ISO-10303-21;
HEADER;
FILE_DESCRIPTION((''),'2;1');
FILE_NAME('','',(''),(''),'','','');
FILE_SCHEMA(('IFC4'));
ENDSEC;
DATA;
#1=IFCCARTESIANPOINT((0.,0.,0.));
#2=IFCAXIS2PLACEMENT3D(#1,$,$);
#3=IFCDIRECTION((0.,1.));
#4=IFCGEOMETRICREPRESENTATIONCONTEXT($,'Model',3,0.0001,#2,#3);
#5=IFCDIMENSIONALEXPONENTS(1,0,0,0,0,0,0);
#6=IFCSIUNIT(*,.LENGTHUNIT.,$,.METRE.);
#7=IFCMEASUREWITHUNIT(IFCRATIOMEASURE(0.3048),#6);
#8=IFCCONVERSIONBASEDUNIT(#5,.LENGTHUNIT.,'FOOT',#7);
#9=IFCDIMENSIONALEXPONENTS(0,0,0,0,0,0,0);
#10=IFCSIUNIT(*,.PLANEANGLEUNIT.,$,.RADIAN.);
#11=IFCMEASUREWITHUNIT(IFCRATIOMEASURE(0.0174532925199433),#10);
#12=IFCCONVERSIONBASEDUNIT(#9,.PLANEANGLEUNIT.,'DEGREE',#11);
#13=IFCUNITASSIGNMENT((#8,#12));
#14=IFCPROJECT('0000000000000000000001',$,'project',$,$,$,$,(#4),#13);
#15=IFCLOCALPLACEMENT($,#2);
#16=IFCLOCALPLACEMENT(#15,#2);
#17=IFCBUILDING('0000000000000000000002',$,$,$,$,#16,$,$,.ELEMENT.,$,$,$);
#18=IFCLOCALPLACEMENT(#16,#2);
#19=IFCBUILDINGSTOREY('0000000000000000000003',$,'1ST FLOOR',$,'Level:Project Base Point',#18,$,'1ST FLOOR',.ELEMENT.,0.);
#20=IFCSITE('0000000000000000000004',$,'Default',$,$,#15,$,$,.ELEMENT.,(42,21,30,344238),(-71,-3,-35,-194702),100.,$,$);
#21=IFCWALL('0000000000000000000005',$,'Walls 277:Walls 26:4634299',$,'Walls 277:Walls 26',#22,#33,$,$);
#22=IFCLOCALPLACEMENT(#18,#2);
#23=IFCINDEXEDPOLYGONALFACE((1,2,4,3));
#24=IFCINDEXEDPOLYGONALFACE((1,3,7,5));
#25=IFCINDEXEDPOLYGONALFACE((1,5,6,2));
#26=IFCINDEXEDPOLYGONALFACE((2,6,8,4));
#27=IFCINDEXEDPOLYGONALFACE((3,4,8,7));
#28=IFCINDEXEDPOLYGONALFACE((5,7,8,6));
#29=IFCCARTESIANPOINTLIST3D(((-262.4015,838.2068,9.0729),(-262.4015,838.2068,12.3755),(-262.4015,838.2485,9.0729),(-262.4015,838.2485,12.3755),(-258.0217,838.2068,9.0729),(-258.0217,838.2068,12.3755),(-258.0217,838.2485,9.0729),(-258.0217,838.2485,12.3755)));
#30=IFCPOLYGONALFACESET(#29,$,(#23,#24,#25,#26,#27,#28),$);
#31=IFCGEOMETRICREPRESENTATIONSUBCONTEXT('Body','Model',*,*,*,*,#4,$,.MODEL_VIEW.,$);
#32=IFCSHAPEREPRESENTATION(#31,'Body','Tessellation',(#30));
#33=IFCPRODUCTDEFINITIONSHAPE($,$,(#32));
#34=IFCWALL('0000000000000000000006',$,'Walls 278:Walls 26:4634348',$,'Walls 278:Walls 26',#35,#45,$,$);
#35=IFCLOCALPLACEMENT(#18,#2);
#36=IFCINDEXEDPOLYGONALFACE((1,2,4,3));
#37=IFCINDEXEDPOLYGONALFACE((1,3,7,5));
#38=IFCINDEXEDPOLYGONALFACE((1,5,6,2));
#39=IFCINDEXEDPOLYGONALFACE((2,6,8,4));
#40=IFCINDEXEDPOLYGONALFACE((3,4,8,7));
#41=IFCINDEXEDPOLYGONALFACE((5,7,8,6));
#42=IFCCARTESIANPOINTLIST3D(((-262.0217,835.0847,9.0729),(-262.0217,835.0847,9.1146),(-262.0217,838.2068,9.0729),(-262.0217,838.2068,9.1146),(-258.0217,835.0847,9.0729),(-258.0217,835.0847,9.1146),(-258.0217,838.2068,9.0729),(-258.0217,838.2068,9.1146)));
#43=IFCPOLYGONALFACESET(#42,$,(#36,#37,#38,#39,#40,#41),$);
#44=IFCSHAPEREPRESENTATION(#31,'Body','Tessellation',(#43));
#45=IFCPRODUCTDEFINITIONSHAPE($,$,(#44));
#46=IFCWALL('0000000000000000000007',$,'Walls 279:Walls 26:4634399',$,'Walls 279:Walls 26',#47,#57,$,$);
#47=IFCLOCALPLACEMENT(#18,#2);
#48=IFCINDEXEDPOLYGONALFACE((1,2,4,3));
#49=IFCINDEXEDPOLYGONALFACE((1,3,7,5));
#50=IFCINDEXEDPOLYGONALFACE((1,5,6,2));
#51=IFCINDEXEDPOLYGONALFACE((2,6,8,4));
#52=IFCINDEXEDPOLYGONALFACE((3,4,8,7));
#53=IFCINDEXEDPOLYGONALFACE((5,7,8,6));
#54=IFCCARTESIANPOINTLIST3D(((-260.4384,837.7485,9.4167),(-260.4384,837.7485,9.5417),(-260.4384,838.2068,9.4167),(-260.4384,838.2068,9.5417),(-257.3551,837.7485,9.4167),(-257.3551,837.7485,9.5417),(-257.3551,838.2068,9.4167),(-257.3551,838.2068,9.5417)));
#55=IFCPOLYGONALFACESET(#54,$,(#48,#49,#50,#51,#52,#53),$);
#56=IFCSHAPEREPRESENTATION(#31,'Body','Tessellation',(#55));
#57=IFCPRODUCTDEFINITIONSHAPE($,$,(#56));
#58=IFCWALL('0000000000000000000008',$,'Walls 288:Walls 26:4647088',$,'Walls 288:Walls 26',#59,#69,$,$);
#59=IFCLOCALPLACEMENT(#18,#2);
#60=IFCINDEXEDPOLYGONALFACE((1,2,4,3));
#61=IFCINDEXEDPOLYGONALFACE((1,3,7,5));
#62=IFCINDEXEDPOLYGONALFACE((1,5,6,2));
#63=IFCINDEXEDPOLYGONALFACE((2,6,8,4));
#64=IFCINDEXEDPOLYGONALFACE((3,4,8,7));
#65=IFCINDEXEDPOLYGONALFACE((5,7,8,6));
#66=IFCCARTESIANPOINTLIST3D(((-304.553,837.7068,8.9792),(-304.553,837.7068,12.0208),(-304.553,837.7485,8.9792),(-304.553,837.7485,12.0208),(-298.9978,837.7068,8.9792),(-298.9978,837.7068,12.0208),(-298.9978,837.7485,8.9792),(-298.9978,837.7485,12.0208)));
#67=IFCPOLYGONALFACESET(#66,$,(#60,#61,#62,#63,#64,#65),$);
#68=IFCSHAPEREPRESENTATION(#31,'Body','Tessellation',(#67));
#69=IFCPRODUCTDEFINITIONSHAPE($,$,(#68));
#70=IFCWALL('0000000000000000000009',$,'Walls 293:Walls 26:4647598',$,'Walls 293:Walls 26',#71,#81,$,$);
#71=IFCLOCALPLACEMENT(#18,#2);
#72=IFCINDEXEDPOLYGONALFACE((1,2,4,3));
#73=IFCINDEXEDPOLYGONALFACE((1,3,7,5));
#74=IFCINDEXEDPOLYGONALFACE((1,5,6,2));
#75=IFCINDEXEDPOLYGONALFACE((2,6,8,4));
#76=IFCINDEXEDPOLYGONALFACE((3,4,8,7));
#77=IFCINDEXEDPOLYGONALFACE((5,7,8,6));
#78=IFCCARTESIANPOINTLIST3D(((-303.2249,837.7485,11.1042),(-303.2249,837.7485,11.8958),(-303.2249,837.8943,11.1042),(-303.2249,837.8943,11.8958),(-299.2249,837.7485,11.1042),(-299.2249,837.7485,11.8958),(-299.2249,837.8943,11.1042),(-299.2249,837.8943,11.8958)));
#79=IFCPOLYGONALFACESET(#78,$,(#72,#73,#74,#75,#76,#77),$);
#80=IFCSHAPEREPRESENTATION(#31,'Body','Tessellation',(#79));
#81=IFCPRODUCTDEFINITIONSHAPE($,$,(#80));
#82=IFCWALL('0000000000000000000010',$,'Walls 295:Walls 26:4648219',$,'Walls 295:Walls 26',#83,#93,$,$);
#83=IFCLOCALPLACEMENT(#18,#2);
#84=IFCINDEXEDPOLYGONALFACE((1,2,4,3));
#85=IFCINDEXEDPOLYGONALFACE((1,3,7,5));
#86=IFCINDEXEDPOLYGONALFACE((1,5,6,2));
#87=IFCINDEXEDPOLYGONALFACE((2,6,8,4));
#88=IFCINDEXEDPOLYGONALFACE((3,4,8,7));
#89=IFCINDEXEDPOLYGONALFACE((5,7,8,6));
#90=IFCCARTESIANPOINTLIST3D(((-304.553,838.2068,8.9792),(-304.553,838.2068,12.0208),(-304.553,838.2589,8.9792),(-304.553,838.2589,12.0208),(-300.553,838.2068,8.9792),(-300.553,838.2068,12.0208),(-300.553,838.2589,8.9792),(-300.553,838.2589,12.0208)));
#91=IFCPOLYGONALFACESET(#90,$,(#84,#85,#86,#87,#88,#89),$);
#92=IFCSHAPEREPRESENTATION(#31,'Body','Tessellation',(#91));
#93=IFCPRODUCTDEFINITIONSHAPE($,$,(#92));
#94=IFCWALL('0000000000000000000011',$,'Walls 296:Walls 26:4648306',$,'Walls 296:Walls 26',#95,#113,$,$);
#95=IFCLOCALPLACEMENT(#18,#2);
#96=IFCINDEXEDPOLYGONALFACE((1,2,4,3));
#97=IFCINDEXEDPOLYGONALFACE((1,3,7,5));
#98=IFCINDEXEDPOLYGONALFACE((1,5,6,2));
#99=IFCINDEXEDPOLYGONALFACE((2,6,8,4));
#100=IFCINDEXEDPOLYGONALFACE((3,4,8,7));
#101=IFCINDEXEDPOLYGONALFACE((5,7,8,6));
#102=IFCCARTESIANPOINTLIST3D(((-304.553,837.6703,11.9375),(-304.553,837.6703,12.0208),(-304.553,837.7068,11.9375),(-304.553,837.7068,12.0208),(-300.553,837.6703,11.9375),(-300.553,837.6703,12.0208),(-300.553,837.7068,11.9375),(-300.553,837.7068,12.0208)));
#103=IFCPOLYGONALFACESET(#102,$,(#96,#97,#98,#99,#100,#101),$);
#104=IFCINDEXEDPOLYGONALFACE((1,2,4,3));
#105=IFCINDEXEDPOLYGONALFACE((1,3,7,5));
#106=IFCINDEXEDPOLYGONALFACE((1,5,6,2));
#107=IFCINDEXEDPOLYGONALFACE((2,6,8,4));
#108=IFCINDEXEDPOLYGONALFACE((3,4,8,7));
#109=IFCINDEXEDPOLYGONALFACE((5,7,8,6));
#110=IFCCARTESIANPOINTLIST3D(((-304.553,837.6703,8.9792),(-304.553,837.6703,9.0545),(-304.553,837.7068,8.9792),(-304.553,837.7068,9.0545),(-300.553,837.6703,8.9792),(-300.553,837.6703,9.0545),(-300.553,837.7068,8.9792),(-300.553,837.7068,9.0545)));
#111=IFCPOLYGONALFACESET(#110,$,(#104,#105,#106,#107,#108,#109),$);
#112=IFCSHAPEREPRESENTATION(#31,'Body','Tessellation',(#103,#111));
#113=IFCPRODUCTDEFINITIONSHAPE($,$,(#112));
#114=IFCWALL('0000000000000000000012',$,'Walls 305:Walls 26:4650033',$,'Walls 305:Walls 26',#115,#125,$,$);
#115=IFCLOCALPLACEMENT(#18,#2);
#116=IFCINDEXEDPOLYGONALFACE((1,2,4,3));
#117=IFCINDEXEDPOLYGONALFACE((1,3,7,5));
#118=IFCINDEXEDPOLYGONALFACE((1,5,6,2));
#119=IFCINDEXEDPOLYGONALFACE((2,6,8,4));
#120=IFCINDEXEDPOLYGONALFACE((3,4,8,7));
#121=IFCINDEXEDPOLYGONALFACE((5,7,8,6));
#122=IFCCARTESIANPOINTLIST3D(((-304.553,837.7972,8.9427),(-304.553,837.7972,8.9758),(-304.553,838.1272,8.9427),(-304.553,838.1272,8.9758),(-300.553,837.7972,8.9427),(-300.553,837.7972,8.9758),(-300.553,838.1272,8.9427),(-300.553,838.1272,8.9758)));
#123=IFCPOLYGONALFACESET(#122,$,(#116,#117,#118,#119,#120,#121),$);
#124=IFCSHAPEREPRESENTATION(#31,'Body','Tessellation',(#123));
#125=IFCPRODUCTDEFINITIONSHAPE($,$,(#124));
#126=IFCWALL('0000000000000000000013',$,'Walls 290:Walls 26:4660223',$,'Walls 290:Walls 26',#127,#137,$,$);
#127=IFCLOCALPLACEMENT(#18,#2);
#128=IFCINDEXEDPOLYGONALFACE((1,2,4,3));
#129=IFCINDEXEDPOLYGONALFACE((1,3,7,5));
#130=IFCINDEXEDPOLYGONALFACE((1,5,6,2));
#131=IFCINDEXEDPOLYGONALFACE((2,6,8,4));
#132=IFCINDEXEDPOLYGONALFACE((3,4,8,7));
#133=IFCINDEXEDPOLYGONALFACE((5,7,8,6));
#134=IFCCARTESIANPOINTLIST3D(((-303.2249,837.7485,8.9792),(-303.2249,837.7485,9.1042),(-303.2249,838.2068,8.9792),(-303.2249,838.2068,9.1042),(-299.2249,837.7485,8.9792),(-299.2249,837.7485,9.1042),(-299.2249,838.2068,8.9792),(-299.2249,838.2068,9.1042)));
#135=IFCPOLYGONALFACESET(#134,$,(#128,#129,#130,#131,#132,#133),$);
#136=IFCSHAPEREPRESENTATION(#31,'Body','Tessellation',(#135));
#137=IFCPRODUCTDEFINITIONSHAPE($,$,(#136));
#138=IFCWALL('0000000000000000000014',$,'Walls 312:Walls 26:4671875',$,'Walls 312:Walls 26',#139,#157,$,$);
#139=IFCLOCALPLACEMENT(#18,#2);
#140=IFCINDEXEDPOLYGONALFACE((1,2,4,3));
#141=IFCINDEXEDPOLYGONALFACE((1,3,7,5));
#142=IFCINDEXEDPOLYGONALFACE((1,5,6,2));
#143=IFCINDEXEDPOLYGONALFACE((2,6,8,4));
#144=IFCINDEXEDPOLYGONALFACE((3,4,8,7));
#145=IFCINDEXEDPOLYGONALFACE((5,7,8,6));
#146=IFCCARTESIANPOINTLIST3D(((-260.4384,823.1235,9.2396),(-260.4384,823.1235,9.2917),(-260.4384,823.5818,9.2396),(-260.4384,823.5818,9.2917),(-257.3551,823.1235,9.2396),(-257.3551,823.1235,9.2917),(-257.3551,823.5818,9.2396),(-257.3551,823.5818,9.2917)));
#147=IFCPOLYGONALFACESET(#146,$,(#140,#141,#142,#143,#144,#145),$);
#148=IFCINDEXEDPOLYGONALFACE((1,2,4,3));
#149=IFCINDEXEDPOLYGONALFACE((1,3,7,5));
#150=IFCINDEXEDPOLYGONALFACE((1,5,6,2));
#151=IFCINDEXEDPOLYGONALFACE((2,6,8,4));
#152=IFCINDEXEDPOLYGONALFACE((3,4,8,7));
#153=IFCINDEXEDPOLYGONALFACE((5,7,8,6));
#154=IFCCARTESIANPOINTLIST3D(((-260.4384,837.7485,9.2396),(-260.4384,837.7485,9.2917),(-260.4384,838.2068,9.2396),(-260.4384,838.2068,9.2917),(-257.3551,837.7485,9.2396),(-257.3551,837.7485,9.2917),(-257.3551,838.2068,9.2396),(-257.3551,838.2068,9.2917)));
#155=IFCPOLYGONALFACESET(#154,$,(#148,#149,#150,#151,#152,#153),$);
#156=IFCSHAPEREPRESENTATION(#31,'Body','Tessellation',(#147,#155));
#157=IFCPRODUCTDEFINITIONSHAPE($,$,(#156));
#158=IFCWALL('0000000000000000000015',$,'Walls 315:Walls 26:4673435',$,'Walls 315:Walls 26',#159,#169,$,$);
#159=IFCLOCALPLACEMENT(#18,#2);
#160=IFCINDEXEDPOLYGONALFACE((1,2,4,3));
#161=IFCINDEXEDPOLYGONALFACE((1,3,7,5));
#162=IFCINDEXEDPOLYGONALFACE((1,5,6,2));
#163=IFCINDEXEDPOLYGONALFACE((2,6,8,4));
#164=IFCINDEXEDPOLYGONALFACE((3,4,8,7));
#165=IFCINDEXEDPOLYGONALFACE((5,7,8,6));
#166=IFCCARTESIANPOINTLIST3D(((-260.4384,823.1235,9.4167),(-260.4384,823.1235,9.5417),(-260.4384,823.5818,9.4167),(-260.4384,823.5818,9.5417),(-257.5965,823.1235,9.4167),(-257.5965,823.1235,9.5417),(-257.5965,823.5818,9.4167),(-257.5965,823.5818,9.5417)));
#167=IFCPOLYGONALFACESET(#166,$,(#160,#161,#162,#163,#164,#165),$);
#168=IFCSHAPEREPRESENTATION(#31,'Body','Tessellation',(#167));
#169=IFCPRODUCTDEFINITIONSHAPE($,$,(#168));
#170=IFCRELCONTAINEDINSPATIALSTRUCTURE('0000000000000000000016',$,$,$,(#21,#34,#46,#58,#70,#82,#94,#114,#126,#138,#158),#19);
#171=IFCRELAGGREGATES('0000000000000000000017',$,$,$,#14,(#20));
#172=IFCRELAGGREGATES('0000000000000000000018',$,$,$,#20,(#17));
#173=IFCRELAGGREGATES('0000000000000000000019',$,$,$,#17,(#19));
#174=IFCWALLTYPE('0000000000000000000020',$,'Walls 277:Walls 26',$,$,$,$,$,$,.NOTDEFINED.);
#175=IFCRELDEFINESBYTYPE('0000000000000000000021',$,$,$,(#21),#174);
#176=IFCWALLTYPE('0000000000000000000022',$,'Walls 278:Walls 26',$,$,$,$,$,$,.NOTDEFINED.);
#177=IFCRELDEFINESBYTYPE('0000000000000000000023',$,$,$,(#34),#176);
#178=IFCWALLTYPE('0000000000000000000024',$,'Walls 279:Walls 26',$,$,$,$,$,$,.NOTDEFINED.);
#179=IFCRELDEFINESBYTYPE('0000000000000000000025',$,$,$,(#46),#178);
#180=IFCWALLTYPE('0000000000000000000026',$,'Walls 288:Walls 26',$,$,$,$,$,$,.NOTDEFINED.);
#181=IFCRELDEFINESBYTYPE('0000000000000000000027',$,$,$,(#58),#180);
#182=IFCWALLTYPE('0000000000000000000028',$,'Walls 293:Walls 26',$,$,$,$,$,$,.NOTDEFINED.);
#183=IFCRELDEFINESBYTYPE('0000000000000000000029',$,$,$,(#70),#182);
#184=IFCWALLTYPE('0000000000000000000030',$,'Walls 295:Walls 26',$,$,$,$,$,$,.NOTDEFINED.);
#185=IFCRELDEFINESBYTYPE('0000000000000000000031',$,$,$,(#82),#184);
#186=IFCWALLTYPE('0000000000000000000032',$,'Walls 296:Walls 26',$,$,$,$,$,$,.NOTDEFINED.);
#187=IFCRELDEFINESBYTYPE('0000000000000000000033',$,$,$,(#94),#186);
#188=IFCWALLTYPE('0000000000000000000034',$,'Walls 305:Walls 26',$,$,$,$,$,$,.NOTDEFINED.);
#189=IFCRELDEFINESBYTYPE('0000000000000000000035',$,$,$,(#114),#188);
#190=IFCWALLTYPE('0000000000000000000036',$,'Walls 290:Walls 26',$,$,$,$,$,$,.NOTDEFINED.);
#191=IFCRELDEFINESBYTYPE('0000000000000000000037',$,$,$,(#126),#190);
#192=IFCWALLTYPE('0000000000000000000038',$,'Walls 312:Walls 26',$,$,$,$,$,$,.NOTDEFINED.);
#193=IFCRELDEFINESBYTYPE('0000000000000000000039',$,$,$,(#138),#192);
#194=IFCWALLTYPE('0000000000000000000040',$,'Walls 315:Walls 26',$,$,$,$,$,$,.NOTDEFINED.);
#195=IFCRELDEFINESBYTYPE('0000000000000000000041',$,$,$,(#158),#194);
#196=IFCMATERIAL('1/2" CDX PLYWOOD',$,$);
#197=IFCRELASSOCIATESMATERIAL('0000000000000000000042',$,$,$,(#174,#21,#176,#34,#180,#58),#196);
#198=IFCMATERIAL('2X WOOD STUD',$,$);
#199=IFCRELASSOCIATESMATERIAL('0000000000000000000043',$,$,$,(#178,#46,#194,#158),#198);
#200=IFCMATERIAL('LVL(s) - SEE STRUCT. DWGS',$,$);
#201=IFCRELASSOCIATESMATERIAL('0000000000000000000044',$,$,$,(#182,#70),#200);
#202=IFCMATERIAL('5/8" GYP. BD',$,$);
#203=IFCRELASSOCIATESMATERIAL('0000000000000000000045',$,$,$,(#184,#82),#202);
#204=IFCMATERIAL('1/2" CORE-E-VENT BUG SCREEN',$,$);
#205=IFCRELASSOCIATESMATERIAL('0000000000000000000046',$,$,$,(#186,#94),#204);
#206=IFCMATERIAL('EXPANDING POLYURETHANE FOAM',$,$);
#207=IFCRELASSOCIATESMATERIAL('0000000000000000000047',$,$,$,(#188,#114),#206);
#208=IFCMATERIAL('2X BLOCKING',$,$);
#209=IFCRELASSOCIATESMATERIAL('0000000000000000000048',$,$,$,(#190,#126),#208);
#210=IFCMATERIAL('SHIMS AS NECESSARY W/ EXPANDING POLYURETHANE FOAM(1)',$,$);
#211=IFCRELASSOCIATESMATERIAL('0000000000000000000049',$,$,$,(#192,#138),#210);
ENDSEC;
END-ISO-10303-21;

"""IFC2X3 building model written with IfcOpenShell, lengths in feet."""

from ifc_helpers import new_model, entity, si_unit, converted_unit, direction, frame, frame_2d, origin, origin_2d_with_axis, place, context, subcontext, project, spatial, rectangle, extrude, material, type_object, element, save


model = new_model("IFC2X3")

# Units and contexts
model_context = context("Model", 3, precision=0.0001, world=origin(), true_north=direction((0.0, 1.0)))
body_context = subcontext(model_context, "Body", "Model", "MODEL_VIEW")
ifc_project = project(units=[converted_unit("LENGTHUNIT", "FOOT", entity("IfcRatioMeasure", 0.3048), si_unit("LENGTHUNIT", "METRE"), dimensions=[1, 0, 0, 0, 0, 0, 0]), converted_unit("PLANEANGLEUNIT", "DEGREE", entity("IfcRatioMeasure", 0.0174532925199433), si_unit("PLANEANGLEUNIT", "RADIAN"), dimensions=[0, 0, 0, 0, 0, 0, 0])], contexts=[model_context])

# Site, building, storey
site_placement = place(None, origin())
site = spatial("IfcSite", under=ifc_project, at=site_placement, Name="Default", CompositionType="ELEMENT", RefLatitude=(42, 21, 30, 344238), RefLongitude=(-71, -3, -35, -194702), RefElevation=100.0)
building_placement = place(site_placement, origin())
building = spatial("IfcBuilding", under=site, at=building_placement, CompositionType="ELEMENT")
storey_placement = place(building_placement, origin())
storey = spatial("IfcBuildingStorey", under=building, at=storey_placement, Name="1ST FLOOR", ObjectType="Level:Project Base Point", LongName="1ST FLOOR", CompositionType="ELEMENT", Elevation=0.0)

# Walls
ifc_material_1 = material(Name="1/2\" CDX PLYWOOD")
ifc_material_2 = material(Name="2X BLOCKING")
ifc_material_3 = material(Name="1/2\" CORE-E-VENT BUG SCREEN")
ifc_material_4 = material(Name="2X WOOD STUD")
wall_type_1 = type_object("IfcWallType", Name="Walls 277:Walls 26", PredefinedType="NOTDEFINED", material=ifc_material_1)
wall_1_placement = place(storey_placement, frame((-262.4015, 838.2068, 9.0729)))
element("IfcWall", 1, at=wall_1_placement, inside=storey, type_object=wall_type_1, material=ifc_material_1, Name="Walls 277:Walls 26:4634299", ObjectType="Walls 277:Walls 26", context=body_context, shape_type="SweptSolid", body=[
    extrude(rectangle(XDim=4.3798, YDim=0.0417, at=frame_2d((0.0, 0.0), x_axis=(1.0, 0.0))), frame((2.1899, 0.0208, 0.0), z_axis=(0.0, 0.0, 1.0), x_axis=(-1.0, 0.0, 0.0)), (0.0, 0.0, 1.0), 3.3025),
])
wall_type_2 = type_object("IfcWallType", Name="Walls 278:Walls 26", PredefinedType="NOTDEFINED", material=ifc_material_1)
wall_2_placement = place(storey_placement, frame((-262.0217, 835.0847, 9.0729)))
element("IfcWall", 2, at=wall_2_placement, inside=storey, type_object=wall_type_2, material=ifc_material_1, Name="Walls 278:Walls 26:4634348", ObjectType="Walls 278:Walls 26", context=body_context, shape_type="SweptSolid", body=[
    extrude(rectangle(XDim=4.0, YDim=3.1221, at=frame_2d((0.0, 0.0), x_axis=(1.0, 0.0))), frame((2.0, 1.5611, 0.0), z_axis=(0.0, 0.0, 1.0), x_axis=(-1.0, 0.0, 0.0)), (0.0, 0.0, 1.0), 0.0417),
])
wall_type_3 = type_object("IfcWallType", Name="Walls 279:Walls 26", PredefinedType="NOTDEFINED", material=ifc_material_4)
wall_3_placement = place(storey_placement, frame((-260.4384, 837.7485, 9.4167)))
element("IfcWall", 3, at=wall_3_placement, inside=storey, type_object=wall_type_3, material=ifc_material_4, Name="Walls 279:Walls 26:4634399", ObjectType="Walls 279:Walls 26", context=body_context, shape_type="SweptSolid", body=[
    extrude(rectangle(XDim=3.0833, YDim=0.4583, at=frame_2d((0.0, 0.0), x_axis=(1.0, 0.0))), frame((1.5417, 0.2292, 0.0), z_axis=(0.0, 0.0, 1.0), x_axis=(-1.0, 0.0, 0.0)), (0.0, 0.0, 1.0), 0.125),
])
wall_type_4 = type_object("IfcWallType", Name="Walls 288:Walls 26", PredefinedType="NOTDEFINED", material=ifc_material_1)
wall_4_placement = place(storey_placement, frame((-304.553, 837.7068, 8.9792)))
element("IfcWall", 4, at=wall_4_placement, inside=storey, type_object=wall_type_4, material=ifc_material_1, Name="Walls 288:Walls 26:4647088", ObjectType="Walls 288:Walls 26", context=body_context, shape_type="SweptSolid", body=[
    extrude(rectangle(XDim=5.5551, YDim=0.0417, at=frame_2d((0.0, 0.0), x_axis=(1.0, 0.0))), frame((2.7776, 0.0208, 0.0), z_axis=(0.0, 0.0, 1.0), x_axis=(-1.0, 0.0, 0.0)), (0.0, 0.0, 1.0), 3.0417),
])
ifc_material_5 = material(Name="LVL(s) - SEE STRUCT. DWGS")
wall_type_5 = type_object("IfcWallType", Name="Walls 293:Walls 26", PredefinedType="NOTDEFINED", material=ifc_material_5)
wall_5_placement = place(storey_placement, frame((-303.2249, 837.7485, 11.1042)))
element("IfcWall", 5, at=wall_5_placement, inside=storey, type_object=wall_type_5, material=ifc_material_5, Name="Walls 293:Walls 26:4647598", ObjectType="Walls 293:Walls 26", context=body_context, shape_type="SweptSolid", body=[
    extrude(rectangle(XDim=4.0, YDim=0.1458, at=frame_2d((0.0, 0.0), x_axis=(1.0, 0.0))), frame((2.0, 0.0729, 0.0), z_axis=(0.0, 0.0, 1.0), x_axis=(-1.0, 0.0, 0.0)), (0.0, 0.0, 1.0), 0.7917),
])
ifc_material_6 = material(Name="5/8\" GYP. BD")
wall_type_6 = type_object("IfcWallType", Name="Walls 295:Walls 26", PredefinedType="NOTDEFINED", material=ifc_material_6)
wall_6_placement = place(storey_placement, frame((-304.553, 838.2068, 8.9792)))
element("IfcWall", 6, at=wall_6_placement, inside=storey, type_object=wall_type_6, material=ifc_material_6, Name="Walls 295:Walls 26:4648219", ObjectType="Walls 295:Walls 26", context=body_context, shape_type="SweptSolid", body=[
    extrude(rectangle(XDim=4.0, YDim=0.0521, at=frame_2d((0.0, 0.0), x_axis=(1.0, 0.0))), frame((2.0, 0.026, 0.0), z_axis=(0.0, 0.0, 1.0), x_axis=(-1.0, 0.0, 0.0)), (0.0, 0.0, 1.0), 3.0417),
])
wall_type_7 = type_object("IfcWallType", Name="Walls 296:Walls 26", PredefinedType="NOTDEFINED", material=ifc_material_3)
wall_7_placement = place(storey_placement, frame((-304.553, 837.6703, 8.9792)))
element("IfcWall", 7, at=wall_7_placement, inside=storey, type_object=wall_type_7, material=ifc_material_3, Name="Walls 296:Walls 26:4648306", ObjectType="Walls 296:Walls 26", context=body_context, shape_type="SweptSolid", body=[
    extrude(rectangle(XDim=4.0, YDim=0.0365, at=origin_2d_with_axis()), frame((2.0, 0.0182, 2.9583), z_axis=(0.0, 0.0, 1.0), x_axis=(-1.0, 0.0, 0.0)), (0.0, 0.0, 1.0), 0.0833),
    extrude(rectangle(XDim=4.0, YDim=0.0365, at=origin_2d_with_axis()), frame((2.0, 0.0182, 0.0), z_axis=(0.0, 0.0, 1.0), x_axis=(-1.0, 0.0, 0.0)), (0.0, 0.0, 1.0), 0.0753),
])
ifc_material_7 = material(Name="EXPANDING POLYURETHANE FOAM")
wall_type_8 = type_object("IfcWallType", Name="Walls 305:Walls 26", PredefinedType="NOTDEFINED", material=ifc_material_7)
wall_8_placement = place(storey_placement, frame((-304.553, 837.7972, 8.9427)))
element("IfcWall", 8, at=wall_8_placement, inside=storey, type_object=wall_type_8, material=ifc_material_7, Name="Walls 305:Walls 26:4650033", ObjectType="Walls 305:Walls 26", context=body_context, shape_type="SweptSolid", body=[
    extrude(rectangle(XDim=4.0, YDim=0.33, at=frame_2d((0.0, 0.0), x_axis=(1.0, 0.0))), frame((2.0, 0.165, 0.0), z_axis=(0.0, 0.0, 1.0), x_axis=(-1.0, 0.0, 0.0)), (0.0, 0.0, 1.0), 0.0331),
])
wall_type_9 = type_object("IfcWallType", Name="Walls 290:Walls 26", PredefinedType="NOTDEFINED", material=ifc_material_2)
wall_9_placement = place(storey_placement, frame((-303.2249, 837.7485, 8.9792)))
element("IfcWall", 9, at=wall_9_placement, inside=storey, type_object=wall_type_9, material=ifc_material_2, Name="Walls 290:Walls 26:4660223", ObjectType="Walls 290:Walls 26", context=body_context, shape_type="SweptSolid", body=[
    extrude(rectangle(XDim=4.0, YDim=0.4583, at=origin_2d_with_axis()), frame((2.0, 0.2292, 0.0), z_axis=(0.0, 0.0, 1.0), x_axis=(-1.0, 0.0, 0.0)), (0.0, 0.0, 1.0), 0.125),
])
ifc_material_8 = material(Name="SHIMS AS NECESSARY W/ EXPANDING POLYURETHANE FOAM(1)")
wall_type_10 = type_object("IfcWallType", Name="Walls 312:Walls 26", PredefinedType="NOTDEFINED", material=ifc_material_8)
wall_10_placement = place(storey_placement, frame((-260.4384, 823.1235, 9.2396), z_axis=(0.0, 0.0, 1.0), x_axis=(0.0, 1.0, 0.0)))
element("IfcWall", 10, at=wall_10_placement, inside=storey, type_object=wall_type_10, material=ifc_material_8, Name="Walls 312:Walls 26:4671875", ObjectType="Walls 312:Walls 26", context=body_context, shape_type="SweptSolid", body=[
    extrude(rectangle(XDim=3.0833, YDim=0.4583, at=frame_2d((0.0, 0.0), x_axis=(1.0, 0.0))), frame((0.2292, -1.5417, 0.0), z_axis=(0.0, 0.0, 1.0), x_axis=(0.0, 1.0, 0.0)), (0.0, 0.0, 1.0), 0.0521),
    extrude(rectangle(XDim=3.0833, YDim=0.4583, at=frame_2d((0.0, 0.0), x_axis=(1.0, 0.0))), frame((14.8542, -1.5417, 0.0), z_axis=(0.0, 0.0, 1.0), x_axis=(0.0, 1.0, 0.0)), (0.0, 0.0, 1.0), 0.0521),
])
wall_type_11 = type_object("IfcWallType", Name="Walls 315:Walls 26", PredefinedType="NOTDEFINED", material=ifc_material_4)
wall_11_placement = place(storey_placement, frame((-260.4384, 823.1235, 9.4167)))
element("IfcWall", 11, at=wall_11_placement, inside=storey, type_object=wall_type_11, material=ifc_material_4, Name="Walls 315:Walls 26:4673435", ObjectType="Walls 315:Walls 26", context=body_context, shape_type="SweptSolid", body=[
    extrude(rectangle(XDim=2.8419, YDim=0.4583, at=frame_2d((0.0, 0.0), x_axis=(1.0, 0.0))), frame((1.421, 0.2292, 0.0), z_axis=(0.0, 0.0, 1.0), x_axis=(-1.0, 0.0, 0.0)), (0.0, 0.0, 1.0), 0.125),
])

save(model, "model.ifc")
